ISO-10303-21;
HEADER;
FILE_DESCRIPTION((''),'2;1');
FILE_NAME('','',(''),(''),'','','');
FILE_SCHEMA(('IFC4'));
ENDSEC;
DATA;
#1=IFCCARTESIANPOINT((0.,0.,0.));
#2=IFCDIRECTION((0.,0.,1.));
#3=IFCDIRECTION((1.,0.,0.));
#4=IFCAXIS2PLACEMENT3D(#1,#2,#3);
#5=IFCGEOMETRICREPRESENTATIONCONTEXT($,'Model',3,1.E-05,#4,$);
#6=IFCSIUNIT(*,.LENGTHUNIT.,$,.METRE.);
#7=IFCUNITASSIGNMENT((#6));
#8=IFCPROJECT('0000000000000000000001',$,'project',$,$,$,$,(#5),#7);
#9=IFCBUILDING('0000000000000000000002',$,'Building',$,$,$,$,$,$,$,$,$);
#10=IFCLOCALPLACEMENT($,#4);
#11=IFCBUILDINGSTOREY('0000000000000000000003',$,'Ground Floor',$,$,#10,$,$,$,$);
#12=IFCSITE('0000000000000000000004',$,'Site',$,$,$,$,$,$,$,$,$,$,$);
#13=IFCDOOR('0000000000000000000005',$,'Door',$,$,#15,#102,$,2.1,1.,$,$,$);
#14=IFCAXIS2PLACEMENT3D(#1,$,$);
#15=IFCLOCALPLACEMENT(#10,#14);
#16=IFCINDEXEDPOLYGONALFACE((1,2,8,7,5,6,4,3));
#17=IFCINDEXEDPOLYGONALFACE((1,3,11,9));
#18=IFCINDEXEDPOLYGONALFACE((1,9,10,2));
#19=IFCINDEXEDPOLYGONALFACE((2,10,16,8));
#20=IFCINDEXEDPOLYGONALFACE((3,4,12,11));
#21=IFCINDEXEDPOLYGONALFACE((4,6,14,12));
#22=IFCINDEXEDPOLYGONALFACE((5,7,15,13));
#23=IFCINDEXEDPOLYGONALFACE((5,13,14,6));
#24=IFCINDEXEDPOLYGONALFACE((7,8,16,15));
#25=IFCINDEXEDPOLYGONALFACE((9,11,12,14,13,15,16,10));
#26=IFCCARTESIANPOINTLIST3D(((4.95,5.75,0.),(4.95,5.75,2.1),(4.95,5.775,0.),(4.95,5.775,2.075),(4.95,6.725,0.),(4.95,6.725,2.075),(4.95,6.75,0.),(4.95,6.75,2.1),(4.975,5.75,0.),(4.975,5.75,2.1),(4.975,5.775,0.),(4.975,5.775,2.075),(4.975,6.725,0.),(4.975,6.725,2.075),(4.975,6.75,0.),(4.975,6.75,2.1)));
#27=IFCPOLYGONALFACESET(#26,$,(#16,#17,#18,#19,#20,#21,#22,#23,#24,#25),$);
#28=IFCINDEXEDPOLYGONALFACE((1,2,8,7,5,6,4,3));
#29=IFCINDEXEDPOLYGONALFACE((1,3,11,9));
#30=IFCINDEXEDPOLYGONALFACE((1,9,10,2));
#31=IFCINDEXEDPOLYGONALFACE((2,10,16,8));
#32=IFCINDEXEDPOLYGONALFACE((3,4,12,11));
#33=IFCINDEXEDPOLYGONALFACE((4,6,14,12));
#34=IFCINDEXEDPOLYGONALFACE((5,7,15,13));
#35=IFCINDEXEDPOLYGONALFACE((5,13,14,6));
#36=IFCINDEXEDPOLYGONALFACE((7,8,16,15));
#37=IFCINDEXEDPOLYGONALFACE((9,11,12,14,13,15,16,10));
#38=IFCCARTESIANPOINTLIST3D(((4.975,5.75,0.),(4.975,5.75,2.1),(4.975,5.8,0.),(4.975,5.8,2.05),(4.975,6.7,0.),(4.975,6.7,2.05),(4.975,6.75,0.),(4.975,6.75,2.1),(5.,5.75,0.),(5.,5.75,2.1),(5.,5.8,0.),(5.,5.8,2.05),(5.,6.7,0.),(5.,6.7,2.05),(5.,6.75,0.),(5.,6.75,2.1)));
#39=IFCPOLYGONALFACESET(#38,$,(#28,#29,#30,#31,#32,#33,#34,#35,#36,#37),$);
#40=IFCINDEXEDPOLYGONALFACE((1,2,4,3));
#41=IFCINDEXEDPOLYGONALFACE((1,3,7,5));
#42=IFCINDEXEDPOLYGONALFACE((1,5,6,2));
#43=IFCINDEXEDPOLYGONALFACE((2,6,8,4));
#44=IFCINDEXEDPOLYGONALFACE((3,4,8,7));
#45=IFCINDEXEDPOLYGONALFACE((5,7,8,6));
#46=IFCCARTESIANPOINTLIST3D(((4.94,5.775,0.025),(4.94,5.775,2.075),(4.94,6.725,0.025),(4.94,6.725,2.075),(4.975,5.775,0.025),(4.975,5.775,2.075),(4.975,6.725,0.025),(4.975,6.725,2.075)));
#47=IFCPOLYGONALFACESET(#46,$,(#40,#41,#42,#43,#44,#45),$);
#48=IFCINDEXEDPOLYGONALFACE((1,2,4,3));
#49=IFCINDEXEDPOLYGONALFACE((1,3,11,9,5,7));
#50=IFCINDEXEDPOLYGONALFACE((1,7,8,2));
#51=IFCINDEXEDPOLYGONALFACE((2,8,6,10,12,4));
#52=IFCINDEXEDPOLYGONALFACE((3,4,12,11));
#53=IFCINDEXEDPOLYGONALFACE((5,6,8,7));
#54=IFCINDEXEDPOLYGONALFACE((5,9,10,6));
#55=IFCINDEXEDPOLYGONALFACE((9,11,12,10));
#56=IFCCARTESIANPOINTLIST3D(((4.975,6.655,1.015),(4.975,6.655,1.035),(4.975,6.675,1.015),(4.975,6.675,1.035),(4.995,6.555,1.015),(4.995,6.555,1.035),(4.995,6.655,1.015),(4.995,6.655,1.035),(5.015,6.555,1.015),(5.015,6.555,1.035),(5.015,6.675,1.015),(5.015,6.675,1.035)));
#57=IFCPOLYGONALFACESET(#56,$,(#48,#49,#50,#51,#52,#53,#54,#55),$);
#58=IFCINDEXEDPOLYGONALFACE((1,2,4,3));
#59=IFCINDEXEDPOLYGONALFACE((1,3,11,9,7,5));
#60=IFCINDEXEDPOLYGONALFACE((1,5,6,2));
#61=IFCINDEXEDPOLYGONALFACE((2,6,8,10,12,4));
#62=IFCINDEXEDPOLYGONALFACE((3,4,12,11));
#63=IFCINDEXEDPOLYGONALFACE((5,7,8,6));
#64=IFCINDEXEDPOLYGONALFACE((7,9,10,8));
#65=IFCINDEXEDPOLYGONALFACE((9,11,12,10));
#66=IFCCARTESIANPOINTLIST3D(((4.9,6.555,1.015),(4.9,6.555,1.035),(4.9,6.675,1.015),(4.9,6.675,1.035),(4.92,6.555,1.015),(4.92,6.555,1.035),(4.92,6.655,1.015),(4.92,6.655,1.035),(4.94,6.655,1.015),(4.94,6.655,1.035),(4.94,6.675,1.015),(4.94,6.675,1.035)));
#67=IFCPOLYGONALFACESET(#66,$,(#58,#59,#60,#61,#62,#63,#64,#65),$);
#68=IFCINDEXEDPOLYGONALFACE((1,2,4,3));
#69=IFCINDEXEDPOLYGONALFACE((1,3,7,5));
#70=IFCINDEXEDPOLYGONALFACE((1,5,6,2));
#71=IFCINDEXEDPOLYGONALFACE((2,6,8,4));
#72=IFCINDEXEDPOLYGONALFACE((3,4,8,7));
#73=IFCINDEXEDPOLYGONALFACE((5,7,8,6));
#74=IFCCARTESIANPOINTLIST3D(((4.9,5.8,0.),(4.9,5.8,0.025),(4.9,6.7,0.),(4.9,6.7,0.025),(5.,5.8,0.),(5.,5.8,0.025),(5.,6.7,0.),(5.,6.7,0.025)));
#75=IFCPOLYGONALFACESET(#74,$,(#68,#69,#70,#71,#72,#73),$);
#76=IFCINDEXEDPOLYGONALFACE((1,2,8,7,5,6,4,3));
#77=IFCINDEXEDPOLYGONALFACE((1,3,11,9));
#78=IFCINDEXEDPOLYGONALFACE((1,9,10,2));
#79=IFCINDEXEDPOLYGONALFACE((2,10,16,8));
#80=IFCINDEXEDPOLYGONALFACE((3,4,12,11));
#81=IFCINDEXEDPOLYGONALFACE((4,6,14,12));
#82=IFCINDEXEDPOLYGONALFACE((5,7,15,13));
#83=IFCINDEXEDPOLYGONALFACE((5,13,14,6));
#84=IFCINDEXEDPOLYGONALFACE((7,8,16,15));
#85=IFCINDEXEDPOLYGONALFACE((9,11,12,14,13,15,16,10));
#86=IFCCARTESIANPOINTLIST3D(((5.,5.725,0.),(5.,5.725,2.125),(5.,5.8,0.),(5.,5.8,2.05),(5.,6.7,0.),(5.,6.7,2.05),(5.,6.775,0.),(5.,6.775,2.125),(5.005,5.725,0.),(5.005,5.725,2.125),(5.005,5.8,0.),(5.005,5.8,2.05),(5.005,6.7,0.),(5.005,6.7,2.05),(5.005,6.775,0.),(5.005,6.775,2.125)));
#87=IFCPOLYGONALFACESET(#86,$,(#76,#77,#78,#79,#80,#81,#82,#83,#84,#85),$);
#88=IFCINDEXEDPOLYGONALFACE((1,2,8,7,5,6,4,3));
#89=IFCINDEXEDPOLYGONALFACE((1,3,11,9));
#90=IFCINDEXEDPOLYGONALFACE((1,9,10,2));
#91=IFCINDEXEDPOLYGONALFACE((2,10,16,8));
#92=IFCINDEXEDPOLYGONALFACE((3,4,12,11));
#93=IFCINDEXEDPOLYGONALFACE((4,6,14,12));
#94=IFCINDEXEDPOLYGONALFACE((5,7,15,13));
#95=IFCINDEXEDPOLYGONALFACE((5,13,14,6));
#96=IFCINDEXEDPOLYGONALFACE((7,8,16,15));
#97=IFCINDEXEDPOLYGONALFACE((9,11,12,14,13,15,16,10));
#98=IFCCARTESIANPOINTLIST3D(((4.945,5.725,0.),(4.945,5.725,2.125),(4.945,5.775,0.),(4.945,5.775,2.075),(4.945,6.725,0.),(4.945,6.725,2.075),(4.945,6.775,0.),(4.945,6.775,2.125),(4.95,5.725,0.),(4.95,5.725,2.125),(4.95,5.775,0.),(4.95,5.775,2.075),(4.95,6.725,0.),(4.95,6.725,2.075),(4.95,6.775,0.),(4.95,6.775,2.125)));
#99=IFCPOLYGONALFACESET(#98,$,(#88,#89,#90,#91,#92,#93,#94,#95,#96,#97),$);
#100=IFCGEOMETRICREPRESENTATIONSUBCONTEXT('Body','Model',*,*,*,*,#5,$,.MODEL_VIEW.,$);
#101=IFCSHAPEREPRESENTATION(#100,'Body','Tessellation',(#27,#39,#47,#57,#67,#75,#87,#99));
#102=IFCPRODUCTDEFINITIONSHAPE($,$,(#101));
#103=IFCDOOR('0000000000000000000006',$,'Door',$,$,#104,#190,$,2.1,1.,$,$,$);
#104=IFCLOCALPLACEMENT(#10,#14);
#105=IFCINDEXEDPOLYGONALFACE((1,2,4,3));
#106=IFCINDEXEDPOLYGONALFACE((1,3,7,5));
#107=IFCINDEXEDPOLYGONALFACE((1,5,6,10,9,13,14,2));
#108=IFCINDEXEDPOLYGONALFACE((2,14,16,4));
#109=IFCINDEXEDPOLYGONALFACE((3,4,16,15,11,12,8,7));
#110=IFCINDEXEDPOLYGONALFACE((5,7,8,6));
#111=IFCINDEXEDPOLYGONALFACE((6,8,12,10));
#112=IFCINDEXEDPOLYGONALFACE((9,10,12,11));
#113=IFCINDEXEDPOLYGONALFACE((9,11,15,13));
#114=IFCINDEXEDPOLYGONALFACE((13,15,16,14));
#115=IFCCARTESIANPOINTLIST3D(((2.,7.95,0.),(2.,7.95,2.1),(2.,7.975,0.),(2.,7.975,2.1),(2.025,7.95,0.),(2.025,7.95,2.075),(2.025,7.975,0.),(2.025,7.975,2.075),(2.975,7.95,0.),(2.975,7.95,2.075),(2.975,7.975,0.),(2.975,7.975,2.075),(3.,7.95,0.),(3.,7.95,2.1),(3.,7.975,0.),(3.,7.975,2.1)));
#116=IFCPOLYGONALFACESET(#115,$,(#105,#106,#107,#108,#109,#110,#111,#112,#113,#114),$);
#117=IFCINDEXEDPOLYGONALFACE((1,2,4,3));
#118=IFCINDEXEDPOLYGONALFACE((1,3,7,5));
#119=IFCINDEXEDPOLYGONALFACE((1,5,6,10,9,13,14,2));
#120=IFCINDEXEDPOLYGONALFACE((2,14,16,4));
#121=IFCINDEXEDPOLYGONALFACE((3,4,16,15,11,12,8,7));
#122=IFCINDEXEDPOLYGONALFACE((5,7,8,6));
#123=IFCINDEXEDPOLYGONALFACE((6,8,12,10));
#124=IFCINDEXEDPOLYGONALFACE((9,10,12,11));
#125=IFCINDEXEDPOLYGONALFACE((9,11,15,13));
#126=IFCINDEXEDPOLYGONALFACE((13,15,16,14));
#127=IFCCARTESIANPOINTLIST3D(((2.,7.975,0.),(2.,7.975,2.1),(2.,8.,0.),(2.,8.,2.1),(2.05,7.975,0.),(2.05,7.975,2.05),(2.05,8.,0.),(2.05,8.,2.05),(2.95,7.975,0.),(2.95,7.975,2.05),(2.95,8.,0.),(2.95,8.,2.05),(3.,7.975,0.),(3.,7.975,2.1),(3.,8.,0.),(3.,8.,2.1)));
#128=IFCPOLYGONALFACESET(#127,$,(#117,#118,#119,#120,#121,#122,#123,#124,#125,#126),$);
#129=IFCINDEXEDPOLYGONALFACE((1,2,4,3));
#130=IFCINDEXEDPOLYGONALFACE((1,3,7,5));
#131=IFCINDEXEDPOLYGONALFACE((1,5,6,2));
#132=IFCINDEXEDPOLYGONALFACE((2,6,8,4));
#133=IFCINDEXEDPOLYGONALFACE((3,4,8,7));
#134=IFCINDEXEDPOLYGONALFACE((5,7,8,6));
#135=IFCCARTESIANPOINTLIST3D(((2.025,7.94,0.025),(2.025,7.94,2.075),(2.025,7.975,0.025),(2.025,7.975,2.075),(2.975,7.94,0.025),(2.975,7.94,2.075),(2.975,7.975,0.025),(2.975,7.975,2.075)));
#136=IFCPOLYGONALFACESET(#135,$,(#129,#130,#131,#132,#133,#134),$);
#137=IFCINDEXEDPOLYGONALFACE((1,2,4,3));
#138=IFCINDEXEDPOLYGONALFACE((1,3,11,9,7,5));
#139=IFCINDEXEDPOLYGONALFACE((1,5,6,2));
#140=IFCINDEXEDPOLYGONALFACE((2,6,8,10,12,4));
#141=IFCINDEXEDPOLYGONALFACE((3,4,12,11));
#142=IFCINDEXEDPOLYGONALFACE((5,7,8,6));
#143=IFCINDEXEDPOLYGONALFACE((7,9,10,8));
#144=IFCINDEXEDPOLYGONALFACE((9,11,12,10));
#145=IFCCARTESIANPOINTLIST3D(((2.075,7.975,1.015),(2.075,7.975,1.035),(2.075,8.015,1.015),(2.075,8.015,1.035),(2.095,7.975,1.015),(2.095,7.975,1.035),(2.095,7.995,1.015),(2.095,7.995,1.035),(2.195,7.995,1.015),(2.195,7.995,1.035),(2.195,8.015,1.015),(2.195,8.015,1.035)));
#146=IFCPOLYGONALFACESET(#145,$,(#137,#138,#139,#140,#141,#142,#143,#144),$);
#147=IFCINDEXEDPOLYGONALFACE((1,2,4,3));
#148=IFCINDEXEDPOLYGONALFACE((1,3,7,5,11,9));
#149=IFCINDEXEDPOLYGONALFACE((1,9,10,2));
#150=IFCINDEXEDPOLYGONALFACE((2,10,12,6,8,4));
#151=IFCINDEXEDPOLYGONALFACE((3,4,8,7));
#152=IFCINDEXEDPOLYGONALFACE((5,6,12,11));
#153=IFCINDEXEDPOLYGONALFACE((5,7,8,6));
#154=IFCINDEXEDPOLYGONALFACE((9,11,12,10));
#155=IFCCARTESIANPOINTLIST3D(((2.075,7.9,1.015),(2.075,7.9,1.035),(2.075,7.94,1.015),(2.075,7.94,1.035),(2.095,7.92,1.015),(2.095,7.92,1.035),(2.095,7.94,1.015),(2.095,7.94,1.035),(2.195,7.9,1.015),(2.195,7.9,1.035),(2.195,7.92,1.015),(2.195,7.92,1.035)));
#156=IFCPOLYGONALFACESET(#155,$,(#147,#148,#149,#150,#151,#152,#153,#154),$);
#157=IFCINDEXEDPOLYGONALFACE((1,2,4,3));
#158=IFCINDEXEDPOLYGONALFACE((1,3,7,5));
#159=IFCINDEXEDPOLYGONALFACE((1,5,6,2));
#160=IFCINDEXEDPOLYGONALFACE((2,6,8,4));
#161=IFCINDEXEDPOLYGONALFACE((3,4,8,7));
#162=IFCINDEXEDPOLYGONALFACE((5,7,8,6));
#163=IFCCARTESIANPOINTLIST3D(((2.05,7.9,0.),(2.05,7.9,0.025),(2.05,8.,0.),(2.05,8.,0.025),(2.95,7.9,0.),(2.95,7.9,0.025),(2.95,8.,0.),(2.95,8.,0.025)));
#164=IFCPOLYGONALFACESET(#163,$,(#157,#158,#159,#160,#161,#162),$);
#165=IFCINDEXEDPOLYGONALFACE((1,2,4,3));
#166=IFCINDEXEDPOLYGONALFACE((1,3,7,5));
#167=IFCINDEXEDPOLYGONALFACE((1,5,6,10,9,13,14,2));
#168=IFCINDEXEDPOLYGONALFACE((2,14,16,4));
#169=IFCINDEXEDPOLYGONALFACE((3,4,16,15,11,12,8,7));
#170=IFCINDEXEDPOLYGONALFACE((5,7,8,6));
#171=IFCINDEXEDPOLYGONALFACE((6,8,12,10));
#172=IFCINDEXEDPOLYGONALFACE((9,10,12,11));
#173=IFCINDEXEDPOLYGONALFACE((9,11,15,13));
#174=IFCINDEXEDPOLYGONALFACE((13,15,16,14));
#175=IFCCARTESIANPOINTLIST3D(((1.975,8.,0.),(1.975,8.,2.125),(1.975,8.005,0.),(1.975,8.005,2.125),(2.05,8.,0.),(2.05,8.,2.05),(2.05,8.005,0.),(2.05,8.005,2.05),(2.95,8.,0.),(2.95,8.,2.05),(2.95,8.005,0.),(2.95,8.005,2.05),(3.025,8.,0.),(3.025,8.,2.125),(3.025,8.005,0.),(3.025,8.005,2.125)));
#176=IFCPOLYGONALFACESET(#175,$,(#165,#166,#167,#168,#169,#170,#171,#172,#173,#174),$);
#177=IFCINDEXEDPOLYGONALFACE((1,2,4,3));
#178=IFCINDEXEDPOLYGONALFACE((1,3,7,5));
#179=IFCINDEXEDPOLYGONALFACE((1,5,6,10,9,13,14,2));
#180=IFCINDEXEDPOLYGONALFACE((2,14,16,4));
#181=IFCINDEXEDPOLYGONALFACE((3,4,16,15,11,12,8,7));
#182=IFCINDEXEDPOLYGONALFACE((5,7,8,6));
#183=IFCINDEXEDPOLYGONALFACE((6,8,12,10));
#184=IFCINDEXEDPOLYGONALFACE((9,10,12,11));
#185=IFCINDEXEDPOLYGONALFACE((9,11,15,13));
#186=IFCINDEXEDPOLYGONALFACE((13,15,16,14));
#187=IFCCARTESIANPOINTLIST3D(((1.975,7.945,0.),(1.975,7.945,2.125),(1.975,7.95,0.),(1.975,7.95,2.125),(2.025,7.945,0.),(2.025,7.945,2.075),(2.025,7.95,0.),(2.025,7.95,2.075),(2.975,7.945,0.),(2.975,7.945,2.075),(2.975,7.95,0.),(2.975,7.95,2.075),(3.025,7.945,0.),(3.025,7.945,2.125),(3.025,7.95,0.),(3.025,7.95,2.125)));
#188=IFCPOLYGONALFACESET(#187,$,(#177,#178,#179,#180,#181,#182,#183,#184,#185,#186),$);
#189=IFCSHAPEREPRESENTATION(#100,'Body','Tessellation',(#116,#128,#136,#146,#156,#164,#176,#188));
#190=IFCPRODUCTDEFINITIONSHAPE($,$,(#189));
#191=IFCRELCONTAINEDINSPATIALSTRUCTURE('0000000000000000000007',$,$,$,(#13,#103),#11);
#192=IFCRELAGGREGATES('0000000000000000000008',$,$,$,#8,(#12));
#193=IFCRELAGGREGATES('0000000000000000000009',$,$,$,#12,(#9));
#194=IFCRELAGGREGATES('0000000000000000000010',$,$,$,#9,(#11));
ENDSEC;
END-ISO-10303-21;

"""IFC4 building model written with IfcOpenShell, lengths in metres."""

from ifc_helpers import new_model, si_unit, frame, origin_with_axes, place, context, subcontext, project, spatial, line, indexed_curve, outline, extrude, element, save


model = new_model("IFC4")

# Units and contexts
model_context = context("Model", 3, precision=1e-05, world=origin_with_axes())
body_context = subcontext(model_context, "Body", "Model", "MODEL_VIEW")
ifc_project = project(units=[si_unit("LENGTHUNIT", "METRE")], contexts=[model_context])

# Site, building, storey
site = spatial("IfcSite", under=ifc_project, Name="Site")
building = spatial("IfcBuilding", under=site, Name="Building")
storey_placement = place(None, origin_with_axes())
storey = spatial("IfcBuildingStorey", under=building, at=storey_placement, Name="Ground Floor")

# Doors
door_1_placement = place(storey_placement, frame((5.0, 5.75, 0.0), z_axis=(0.0, 0.0, 1.0), x_axis=(0.0, 1.0, 0.0)))
element("IfcDoor", 1, at=door_1_placement, inside=storey, Name="Door", OverallHeight=2.1, OverallWidth=1.0, context=body_context, shape_type="SweptSolid", body=[
    extrude(outline(indexed_curve([(0.0, 0.0), (0.0, 2.1), (1.0, 2.1), (1.0, 0.0), (0.975, 0.0), (0.975, 2.075), (0.025, 2.075), (0.025, 0.0)], segments=[line(1, 2, 3, 4, 5, 6, 7, 8, 1)])), frame((0.0, 0.025, 0.0), z_axis=(0.0, -1.0, 0.0), x_axis=(1.0, 0.0, 0.0)), (0.0, 0.0, -1.0), 0.025),
    extrude(outline(indexed_curve([(0.0, 0.0), (0.0, 2.1), (1.0, 2.1), (1.0, 0.0), (0.95, 0.0), (0.95, 2.05), (0.05, 2.05), (0.05, 0.0)], segments=[line(1, 2, 3, 4, 5, 6, 7, 8, 1)])), frame((0.0, 0.0, 0.0), z_axis=(0.0, -1.0, 0.0), x_axis=(1.0, 0.0, 0.0)), (0.0, 0.0, -1.0), 0.025),
    extrude(outline(indexed_curve([(0.0, 0.0), (0.95, 0.0), (0.95, 0.035), (0.0, 0.035)], segments=[line(1, 2, 3, 4, 1)])), frame((0.025, 0.025, 0.025), z_axis=(0.0, 0.0, 1.0), x_axis=(1.0, 0.0, 0.0)), (0.0, 0.0, 1.0), 2.05),
    extrude(outline(indexed_curve([(0.0, 0.0), (0.0, -0.04), (-0.12, -0.04), (-0.12, -0.02), (-0.02, -0.02), (-0.02, 0.0)], segments=[line(1, 2, 3, 4, 5, 6, 1)])), frame((0.925, 0.025, 1.015), z_axis=(0.0, 0.0, 1.0), x_axis=(1.0, 0.0, 0.0)), (0.0, 0.0, 1.0), 0.02),
    extrude(outline(indexed_curve([(0.0, 0.0), (0.0, 0.04), (-0.12, 0.04), (-0.12, 0.02), (-0.02, 0.02), (-0.02, 0.0)], segments=[line(1, 2, 3, 4, 5, 6, 1)])), frame((0.925, 0.06, 1.015), z_axis=(0.0, 0.0, 1.0), x_axis=(1.0, 0.0, 0.0)), (0.0, 0.0, 1.0), 0.02),
    extrude(outline(indexed_curve([(0.0, 0.0), (0.9, 0.0), (0.9, 0.1), (0.0, 0.1)], segments=[line(1, 2, 3, 4, 1)])), frame((0.05, 0.0, 0.0), z_axis=(0.0, 0.0, 1.0), x_axis=(1.0, 0.0, 0.0)), (0.0, 0.0, 1.0), 0.025),
    extrude(outline(indexed_curve([(0.0, 0.0), (0.0, 2.125), (1.05, 2.125), (1.05, 0.0), (0.975, 0.0), (0.975, 2.05), (0.075, 2.05), (0.075, 0.0)], segments=[line(1, 2, 3, 4, 5, 6, 7, 8, 1)])), frame((-0.025, -0.005, 0.0), z_axis=(0.0, -1.0, 0.0), x_axis=(1.0, 0.0, 0.0)), (0.0, 0.0, -1.0), 0.005),
    extrude(outline(indexed_curve([(0.0, 0.0), (0.0, 2.125), (1.05, 2.125), (1.05, 0.0), (1.0, 0.0), (1.0, 2.075), (0.05, 2.075), (0.05, 0.0)], segments=[line(1, 2, 3, 4, 5, 6, 7, 8, 1)])), frame((-0.025, 0.05, 0.0), z_axis=(0.0, -1.0, 0.0), x_axis=(1.0, 0.0, 0.0)), (0.0, 0.0, -1.0), 0.005),
])
door_2_placement = place(storey_placement, frame((3.0, 8.0, 0.0), z_axis=(0.0, 0.0, 1.0), x_axis=(-1.0, 0.0, 0.0)))
element("IfcDoor", 2, at=door_2_placement, inside=storey, Name="Door", OverallHeight=2.1, OverallWidth=1.0, context=body_context, shape_type="SweptSolid", body=[
    extrude(outline(indexed_curve([(0.0, 0.0), (0.0, 2.1), (1.0, 2.1), (1.0, 0.0), (0.975, 0.0), (0.975, 2.075), (0.025, 2.075), (0.025, 0.0)], segments=[line(1, 2, 3, 4, 5, 6, 7, 8, 1)])), frame((0.0, 0.025, 0.0), z_axis=(0.0, -1.0, 0.0), x_axis=(1.0, 0.0, 0.0)), (0.0, 0.0, -1.0), 0.025),
    extrude(outline(indexed_curve([(0.0, 0.0), (0.0, 2.1), (1.0, 2.1), (1.0, 0.0), (0.95, 0.0), (0.95, 2.05), (0.05, 2.05), (0.05, 0.0)], segments=[line(1, 2, 3, 4, 5, 6, 7, 8, 1)])), frame((0.0, 0.0, 0.0), z_axis=(0.0, -1.0, 0.0), x_axis=(1.0, 0.0, 0.0)), (0.0, 0.0, -1.0), 0.025),
    extrude(outline(indexed_curve([(0.0, 0.0), (0.95, 0.0), (0.95, 0.035), (0.0, 0.035)], segments=[line(1, 2, 3, 4, 1)])), frame((0.025, 0.025, 0.025), z_axis=(0.0, 0.0, 1.0), x_axis=(1.0, 0.0, 0.0)), (0.0, 0.0, 1.0), 2.05),
    extrude(outline(indexed_curve([(0.0, 0.0), (0.0, -0.04), (-0.12, -0.04), (-0.12, -0.02), (-0.02, -0.02), (-0.02, 0.0)], segments=[line(1, 2, 3, 4, 5, 6, 1)])), frame((0.925, 0.025, 1.015), z_axis=(0.0, 0.0, 1.0), x_axis=(1.0, 0.0, 0.0)), (0.0, 0.0, 1.0), 0.02),
    extrude(outline(indexed_curve([(0.0, 0.0), (0.0, 0.04), (-0.12, 0.04), (-0.12, 0.02), (-0.02, 0.02), (-0.02, 0.0)], segments=[line(1, 2, 3, 4, 5, 6, 1)])), frame((0.925, 0.06, 1.015), z_axis=(0.0, 0.0, 1.0), x_axis=(1.0, 0.0, 0.0)), (0.0, 0.0, 1.0), 0.02),
    extrude(outline(indexed_curve([(0.0, 0.0), (0.9, 0.0), (0.9, 0.1), (0.0, 0.1)], segments=[line(1, 2, 3, 4, 1)])), frame((0.05, 0.0, 0.0), z_axis=(0.0, 0.0, 1.0), x_axis=(1.0, 0.0, 0.0)), (0.0, 0.0, 1.0), 0.025),
    extrude(outline(indexed_curve([(0.0, 0.0), (0.0, 2.125), (1.05, 2.125), (1.05, 0.0), (0.975, 0.0), (0.975, 2.05), (0.075, 2.05), (0.075, 0.0)], segments=[line(1, 2, 3, 4, 5, 6, 7, 8, 1)])), frame((-0.025, -0.005, 0.0), z_axis=(0.0, -1.0, 0.0), x_axis=(1.0, 0.0, 0.0)), (0.0, 0.0, -1.0), 0.005),
    extrude(outline(indexed_curve([(0.0, 0.0), (0.0, 2.125), (1.05, 2.125), (1.05, 0.0), (1.0, 0.0), (1.0, 2.075), (0.05, 2.075), (0.05, 0.0)], segments=[line(1, 2, 3, 4, 5, 6, 7, 8, 1)])), frame((-0.025, 0.05, 0.0), z_axis=(0.0, -1.0, 0.0), x_axis=(1.0, 0.0, 0.0)), (0.0, 0.0, -1.0), 0.005),
])

save(model, "model.ifc")
